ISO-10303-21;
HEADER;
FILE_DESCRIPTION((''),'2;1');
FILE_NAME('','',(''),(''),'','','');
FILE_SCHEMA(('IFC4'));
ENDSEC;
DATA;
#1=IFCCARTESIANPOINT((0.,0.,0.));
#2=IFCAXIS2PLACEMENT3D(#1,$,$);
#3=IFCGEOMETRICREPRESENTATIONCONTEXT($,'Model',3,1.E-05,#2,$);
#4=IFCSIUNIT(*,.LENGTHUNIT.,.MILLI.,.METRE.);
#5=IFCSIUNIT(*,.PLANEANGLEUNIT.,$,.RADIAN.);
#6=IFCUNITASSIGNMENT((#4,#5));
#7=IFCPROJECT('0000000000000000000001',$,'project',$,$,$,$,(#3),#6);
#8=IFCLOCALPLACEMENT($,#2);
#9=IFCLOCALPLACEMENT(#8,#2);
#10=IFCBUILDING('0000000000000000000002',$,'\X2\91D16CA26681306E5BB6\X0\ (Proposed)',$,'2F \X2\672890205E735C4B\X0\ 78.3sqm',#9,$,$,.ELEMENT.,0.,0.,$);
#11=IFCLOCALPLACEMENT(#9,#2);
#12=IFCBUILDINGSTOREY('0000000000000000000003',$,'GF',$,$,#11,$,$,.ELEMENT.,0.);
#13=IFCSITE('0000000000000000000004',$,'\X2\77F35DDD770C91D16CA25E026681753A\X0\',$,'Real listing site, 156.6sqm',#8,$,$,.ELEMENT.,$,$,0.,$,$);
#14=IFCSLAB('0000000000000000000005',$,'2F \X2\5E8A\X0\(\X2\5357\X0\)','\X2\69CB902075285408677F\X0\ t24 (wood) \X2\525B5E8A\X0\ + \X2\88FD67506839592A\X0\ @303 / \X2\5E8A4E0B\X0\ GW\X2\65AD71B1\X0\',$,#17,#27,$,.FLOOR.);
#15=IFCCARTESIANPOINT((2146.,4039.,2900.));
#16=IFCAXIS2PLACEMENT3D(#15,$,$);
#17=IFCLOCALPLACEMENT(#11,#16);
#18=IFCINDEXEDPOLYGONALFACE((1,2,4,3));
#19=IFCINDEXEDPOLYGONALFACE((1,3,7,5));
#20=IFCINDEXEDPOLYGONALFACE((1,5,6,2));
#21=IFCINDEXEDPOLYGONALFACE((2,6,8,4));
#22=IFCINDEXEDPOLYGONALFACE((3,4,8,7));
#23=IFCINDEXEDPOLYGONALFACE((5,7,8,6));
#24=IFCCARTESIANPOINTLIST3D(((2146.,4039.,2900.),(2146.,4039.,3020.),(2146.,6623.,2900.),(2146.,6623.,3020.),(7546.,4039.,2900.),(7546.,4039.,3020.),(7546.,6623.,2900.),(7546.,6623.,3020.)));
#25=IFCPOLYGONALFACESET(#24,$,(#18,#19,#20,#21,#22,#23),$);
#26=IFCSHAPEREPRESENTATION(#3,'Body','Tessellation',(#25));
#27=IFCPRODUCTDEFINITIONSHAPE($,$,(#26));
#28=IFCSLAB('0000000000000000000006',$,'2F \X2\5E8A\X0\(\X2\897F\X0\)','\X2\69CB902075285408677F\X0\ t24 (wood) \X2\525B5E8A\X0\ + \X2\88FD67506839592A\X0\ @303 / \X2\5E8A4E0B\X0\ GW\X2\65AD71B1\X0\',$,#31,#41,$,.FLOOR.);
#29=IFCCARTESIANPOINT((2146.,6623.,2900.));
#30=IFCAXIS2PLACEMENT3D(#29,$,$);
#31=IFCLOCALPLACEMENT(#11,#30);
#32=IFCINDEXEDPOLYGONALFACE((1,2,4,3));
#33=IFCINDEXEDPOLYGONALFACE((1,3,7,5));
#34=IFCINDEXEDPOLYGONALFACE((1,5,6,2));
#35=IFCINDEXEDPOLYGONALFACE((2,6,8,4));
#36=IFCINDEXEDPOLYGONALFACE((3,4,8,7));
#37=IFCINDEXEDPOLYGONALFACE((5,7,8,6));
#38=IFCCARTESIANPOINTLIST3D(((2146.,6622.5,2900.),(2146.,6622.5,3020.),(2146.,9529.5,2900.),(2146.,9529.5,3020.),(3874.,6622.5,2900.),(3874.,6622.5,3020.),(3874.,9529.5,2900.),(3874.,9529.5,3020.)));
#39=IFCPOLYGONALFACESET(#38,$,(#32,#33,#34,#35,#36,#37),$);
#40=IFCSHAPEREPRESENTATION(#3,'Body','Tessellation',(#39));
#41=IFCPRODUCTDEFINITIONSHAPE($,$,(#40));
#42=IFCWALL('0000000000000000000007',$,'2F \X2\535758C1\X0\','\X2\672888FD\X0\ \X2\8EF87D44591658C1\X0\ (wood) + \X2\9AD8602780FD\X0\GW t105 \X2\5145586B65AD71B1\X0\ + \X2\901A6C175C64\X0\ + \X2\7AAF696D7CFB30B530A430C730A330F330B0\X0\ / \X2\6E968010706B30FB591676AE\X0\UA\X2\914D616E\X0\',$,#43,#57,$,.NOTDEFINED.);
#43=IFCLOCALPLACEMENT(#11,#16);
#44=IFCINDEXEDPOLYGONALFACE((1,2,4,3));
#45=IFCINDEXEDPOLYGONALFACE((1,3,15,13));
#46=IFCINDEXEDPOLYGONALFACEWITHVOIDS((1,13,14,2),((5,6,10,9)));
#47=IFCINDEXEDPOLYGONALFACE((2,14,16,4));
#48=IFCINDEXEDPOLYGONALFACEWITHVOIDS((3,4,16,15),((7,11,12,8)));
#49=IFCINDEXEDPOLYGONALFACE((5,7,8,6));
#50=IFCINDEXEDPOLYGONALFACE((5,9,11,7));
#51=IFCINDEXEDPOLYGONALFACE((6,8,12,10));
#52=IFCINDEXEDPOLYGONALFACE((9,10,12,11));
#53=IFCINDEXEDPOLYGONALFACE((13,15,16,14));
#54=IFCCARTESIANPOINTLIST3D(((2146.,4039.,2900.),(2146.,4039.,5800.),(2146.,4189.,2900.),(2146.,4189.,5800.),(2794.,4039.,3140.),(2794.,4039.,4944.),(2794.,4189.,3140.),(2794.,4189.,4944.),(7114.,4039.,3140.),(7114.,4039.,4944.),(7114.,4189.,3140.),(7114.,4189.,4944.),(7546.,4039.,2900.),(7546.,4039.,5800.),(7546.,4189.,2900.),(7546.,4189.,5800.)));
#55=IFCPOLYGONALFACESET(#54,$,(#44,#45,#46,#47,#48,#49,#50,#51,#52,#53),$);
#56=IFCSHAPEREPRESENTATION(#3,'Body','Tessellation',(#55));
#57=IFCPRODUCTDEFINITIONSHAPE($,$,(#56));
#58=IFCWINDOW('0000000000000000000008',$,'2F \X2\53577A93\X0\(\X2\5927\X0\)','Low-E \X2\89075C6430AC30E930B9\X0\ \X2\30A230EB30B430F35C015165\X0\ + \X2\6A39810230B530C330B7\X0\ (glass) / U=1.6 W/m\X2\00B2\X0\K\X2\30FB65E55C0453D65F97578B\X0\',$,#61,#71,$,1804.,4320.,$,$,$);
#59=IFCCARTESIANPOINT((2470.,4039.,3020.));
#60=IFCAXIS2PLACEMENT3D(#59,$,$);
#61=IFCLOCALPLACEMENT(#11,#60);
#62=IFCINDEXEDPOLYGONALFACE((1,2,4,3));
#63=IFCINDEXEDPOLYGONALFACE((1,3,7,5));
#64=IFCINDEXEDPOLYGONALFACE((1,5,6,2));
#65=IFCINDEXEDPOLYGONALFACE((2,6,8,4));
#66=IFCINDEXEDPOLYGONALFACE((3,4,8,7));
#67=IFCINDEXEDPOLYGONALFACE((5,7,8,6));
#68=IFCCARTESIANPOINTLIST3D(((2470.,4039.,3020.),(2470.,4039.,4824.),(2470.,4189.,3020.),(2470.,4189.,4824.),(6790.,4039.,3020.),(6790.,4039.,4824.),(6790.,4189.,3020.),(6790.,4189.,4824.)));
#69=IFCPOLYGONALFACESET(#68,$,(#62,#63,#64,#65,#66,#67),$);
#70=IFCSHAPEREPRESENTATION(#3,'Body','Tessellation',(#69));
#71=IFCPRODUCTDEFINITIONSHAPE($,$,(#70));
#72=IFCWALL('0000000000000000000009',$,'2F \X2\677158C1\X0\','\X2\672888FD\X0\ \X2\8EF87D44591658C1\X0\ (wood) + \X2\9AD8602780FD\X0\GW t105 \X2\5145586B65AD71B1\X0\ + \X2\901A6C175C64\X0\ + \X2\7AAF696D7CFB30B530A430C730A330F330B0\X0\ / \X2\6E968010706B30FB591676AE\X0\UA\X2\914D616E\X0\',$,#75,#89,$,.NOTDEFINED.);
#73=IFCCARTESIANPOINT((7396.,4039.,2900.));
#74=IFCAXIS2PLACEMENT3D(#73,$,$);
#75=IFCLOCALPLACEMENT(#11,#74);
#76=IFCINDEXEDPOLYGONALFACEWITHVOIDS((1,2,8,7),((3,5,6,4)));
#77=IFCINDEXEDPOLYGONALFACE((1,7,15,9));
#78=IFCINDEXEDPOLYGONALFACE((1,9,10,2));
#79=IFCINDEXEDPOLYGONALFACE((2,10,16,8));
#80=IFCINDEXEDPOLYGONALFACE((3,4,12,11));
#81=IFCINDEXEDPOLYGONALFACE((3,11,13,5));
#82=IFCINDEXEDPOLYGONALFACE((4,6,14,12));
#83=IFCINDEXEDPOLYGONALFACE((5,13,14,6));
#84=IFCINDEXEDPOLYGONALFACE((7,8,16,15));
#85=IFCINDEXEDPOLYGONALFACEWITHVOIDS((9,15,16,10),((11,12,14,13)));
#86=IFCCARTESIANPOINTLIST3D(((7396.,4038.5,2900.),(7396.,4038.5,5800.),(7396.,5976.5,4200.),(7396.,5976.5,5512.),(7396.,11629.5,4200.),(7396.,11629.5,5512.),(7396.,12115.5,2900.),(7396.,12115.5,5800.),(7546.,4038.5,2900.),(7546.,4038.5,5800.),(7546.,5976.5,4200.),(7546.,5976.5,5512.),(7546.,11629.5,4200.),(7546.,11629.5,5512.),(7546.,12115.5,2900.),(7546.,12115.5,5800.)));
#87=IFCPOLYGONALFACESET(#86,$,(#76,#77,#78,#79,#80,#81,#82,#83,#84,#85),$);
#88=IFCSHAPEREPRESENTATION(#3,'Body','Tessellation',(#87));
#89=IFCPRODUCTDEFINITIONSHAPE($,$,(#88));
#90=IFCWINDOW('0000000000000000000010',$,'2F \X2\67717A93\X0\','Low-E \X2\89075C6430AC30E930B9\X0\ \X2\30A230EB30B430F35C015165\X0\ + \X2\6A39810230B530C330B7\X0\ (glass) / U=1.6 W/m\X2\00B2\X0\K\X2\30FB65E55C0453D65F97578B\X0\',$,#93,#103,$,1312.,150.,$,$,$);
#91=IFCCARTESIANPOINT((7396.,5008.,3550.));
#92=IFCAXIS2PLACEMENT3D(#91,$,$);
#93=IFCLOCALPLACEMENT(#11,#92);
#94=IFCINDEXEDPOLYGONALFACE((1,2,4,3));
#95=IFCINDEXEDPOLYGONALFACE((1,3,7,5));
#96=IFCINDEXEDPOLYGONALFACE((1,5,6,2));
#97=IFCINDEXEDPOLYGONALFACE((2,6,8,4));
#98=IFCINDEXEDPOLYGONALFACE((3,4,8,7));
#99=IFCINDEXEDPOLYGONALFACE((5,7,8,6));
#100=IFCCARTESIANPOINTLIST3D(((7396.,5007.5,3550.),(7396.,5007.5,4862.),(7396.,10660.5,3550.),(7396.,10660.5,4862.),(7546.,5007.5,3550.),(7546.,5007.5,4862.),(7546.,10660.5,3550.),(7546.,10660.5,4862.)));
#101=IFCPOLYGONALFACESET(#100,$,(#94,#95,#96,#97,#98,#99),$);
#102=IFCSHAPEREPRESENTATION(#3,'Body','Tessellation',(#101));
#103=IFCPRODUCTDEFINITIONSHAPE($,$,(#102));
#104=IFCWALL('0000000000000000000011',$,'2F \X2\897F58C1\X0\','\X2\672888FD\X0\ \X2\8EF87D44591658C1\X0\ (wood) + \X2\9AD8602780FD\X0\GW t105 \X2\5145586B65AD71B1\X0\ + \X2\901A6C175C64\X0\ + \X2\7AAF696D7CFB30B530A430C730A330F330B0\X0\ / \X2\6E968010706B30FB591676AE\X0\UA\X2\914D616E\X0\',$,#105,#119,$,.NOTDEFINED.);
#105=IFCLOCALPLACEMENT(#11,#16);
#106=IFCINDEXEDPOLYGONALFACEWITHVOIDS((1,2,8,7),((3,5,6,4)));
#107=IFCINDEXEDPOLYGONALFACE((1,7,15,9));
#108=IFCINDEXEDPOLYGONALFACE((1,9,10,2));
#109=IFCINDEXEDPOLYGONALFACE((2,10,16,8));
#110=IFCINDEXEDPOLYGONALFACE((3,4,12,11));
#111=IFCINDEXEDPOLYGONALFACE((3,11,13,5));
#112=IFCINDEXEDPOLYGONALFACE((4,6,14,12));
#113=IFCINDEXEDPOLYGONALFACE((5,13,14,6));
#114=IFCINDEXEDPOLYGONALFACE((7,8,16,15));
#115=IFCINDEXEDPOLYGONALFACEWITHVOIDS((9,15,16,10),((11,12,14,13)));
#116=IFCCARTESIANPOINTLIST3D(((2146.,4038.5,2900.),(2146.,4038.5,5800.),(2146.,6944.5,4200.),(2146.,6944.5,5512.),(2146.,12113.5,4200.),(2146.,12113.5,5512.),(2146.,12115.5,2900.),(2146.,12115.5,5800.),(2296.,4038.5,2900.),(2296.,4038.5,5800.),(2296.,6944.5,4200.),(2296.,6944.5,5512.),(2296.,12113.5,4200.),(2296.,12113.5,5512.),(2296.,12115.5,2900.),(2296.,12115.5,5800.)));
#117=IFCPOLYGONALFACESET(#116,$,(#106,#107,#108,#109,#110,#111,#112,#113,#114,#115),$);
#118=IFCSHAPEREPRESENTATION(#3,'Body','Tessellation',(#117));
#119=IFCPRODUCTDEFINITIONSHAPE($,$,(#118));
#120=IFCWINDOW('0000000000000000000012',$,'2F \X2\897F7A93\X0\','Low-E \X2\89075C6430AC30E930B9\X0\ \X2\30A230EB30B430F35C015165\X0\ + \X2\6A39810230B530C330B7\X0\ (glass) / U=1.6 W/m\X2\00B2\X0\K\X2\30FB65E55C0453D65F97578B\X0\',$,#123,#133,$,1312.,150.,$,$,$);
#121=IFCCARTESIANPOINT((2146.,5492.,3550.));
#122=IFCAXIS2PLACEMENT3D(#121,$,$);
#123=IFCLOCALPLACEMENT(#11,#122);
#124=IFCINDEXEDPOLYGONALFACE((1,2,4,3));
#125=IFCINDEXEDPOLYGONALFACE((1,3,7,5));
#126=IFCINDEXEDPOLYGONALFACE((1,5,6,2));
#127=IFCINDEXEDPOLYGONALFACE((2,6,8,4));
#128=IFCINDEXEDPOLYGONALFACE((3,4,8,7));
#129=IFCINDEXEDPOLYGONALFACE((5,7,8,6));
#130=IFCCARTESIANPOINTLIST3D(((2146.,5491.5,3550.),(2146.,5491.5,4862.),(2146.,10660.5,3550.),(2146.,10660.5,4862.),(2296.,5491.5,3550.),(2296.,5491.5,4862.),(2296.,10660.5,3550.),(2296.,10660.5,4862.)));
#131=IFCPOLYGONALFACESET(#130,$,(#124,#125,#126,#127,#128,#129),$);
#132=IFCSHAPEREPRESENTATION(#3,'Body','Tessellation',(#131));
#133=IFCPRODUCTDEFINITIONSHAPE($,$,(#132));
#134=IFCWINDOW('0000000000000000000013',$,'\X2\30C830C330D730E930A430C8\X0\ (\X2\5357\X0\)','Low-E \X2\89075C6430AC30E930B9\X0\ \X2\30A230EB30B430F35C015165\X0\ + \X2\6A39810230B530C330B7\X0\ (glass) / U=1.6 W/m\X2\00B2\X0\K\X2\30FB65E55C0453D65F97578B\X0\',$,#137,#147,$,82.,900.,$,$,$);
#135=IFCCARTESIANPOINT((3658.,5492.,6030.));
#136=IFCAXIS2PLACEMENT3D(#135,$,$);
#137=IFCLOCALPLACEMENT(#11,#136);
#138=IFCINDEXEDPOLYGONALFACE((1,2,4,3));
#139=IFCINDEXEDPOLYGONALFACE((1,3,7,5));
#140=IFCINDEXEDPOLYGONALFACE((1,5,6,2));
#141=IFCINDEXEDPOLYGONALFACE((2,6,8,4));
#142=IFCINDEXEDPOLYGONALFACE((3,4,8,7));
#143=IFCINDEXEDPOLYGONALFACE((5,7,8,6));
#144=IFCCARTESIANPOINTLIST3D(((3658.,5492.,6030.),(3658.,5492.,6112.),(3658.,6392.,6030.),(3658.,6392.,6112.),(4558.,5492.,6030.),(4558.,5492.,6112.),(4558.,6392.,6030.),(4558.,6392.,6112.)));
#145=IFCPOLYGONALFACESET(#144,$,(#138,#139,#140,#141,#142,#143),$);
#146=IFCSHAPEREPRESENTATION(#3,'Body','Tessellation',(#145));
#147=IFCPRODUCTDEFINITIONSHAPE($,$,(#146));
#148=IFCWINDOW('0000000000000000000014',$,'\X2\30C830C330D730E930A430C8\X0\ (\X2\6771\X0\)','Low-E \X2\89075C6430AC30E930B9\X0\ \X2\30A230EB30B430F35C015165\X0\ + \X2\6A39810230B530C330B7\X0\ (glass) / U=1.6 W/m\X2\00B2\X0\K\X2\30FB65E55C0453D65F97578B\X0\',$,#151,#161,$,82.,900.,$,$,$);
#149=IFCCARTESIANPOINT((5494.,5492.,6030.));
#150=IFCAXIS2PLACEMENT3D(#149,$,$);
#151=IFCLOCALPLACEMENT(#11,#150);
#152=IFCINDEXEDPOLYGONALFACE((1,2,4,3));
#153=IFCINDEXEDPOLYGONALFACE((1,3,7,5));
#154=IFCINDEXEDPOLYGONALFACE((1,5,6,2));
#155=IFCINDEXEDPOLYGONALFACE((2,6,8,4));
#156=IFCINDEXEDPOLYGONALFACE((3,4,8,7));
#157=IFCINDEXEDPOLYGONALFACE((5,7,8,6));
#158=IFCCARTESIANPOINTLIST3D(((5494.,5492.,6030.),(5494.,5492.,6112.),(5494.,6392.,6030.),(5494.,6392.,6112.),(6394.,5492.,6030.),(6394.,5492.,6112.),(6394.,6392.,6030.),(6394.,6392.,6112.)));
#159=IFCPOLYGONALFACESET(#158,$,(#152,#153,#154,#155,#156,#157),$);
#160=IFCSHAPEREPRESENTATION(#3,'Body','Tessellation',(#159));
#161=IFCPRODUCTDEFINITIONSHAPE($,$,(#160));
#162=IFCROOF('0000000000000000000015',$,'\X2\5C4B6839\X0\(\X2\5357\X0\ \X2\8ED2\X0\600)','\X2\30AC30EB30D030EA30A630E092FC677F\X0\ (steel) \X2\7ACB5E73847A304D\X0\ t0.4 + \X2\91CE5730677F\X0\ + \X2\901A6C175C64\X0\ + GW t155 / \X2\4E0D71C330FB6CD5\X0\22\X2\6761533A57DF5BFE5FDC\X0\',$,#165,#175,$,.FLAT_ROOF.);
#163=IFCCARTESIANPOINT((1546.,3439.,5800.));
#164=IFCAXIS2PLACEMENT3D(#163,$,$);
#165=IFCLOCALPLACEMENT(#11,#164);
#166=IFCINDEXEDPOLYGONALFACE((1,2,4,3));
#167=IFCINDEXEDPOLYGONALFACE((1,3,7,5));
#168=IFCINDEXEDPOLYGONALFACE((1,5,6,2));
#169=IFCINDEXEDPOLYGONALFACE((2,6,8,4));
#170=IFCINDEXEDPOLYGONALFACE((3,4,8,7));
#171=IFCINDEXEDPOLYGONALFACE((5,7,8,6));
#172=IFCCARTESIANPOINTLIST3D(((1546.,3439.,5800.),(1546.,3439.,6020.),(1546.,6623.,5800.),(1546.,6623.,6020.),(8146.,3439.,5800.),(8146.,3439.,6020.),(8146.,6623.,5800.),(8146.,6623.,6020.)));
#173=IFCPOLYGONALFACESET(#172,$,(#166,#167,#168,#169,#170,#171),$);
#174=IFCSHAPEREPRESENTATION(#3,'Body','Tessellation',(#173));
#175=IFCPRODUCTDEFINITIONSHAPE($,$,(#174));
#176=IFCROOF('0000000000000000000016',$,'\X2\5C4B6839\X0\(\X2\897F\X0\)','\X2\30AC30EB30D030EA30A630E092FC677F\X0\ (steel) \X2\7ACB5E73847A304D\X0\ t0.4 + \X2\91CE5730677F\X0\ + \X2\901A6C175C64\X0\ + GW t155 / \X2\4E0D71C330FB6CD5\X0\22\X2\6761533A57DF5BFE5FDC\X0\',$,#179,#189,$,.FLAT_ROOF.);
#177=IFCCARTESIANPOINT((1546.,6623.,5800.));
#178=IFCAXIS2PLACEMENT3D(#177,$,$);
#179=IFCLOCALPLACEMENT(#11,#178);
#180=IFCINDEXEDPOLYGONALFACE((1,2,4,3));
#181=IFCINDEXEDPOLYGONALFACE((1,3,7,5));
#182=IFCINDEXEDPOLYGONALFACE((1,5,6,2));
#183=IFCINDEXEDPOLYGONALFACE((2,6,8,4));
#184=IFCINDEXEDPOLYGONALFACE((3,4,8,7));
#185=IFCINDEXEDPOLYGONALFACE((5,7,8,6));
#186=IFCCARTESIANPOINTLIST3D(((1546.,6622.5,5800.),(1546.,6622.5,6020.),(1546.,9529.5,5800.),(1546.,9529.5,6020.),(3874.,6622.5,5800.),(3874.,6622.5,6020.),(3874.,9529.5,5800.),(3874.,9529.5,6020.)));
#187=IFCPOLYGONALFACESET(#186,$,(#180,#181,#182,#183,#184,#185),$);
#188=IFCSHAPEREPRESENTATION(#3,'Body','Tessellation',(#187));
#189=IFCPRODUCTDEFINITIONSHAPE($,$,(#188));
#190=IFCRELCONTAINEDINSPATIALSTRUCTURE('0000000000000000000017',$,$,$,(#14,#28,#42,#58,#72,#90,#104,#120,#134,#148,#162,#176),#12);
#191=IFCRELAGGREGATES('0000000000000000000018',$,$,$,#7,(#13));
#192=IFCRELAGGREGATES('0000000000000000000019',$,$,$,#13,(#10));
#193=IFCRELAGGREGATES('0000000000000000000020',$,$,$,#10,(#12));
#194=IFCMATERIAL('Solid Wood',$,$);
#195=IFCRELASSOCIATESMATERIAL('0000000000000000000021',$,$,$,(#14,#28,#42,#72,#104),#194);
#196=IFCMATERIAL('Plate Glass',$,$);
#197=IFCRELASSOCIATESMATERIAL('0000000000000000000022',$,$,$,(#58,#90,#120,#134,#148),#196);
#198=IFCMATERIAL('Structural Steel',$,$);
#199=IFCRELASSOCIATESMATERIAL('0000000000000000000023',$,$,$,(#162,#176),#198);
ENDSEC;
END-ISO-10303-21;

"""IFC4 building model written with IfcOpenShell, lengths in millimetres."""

from ifc_helpers import new_model, si_unit, frame, frame_2d, origin, place, context, project, spatial, rectangle, extrude, material, element, fill, save


model = new_model("IFC4")

# Units and contexts
model_context = context("Model", 3, precision=1e-05, world=origin())
ifc_project = project(units=[si_unit("LENGTHUNIT", "METRE", prefix="MILLI"), si_unit("PLANEANGLEUNIT", "RADIAN")], contexts=[model_context])

# Site, building, storey
site_placement = place(None, origin())
site = spatial("IfcSite", under=ifc_project, at=site_placement, Name="石川県金沢市暁町", ObjectType="Real listing site, 156.6sqm", CompositionType="ELEMENT", RefElevation=0.0)
building_placement = place(site_placement, origin())
building = spatial("IfcBuilding", under=site, at=building_placement, Name="金沢暁の家 (Proposed)", ObjectType="2F 木造平屋 78.3sqm", CompositionType="ELEMENT", ElevationOfRefHeight=0.0, ElevationOfTerrain=0.0)
storey_placement = place(building_placement, origin())
storey = spatial("IfcBuildingStorey", under=building, at=storey_placement, Name="GF", CompositionType="ELEMENT", Elevation=0.0)

# Slabs
ifc_material_1 = material(Name="Solid Wood")
slab_1_placement = place(storey_placement, frame((2146.0, 4039.0, 2900.0)))
element("IfcSlab", 1, at=slab_1_placement, inside=storey, material=ifc_material_1, Name="2F 床(南)", Description="構造用合板 t24 (wood) 剛床 + 製材根太 @303 / 床下 GW断熱", PredefinedType="FLOOR", context=model_context, shape_type="SweptSolid", body=[
    extrude(rectangle(XDim=5400.0, YDim=2584.0, at=frame_2d((2700.0, 1292.0))), frame((2146.0, 4039.0, 2900.0)), (0.0, 0.0, 1.0), 120.0),
])
slab_2_placement = place(storey_placement, frame((2146.0, 6623.0, 2900.0)))
element("IfcSlab", 2, at=slab_2_placement, inside=storey, material=ifc_material_1, Name="2F 床(西)", Description="構造用合板 t24 (wood) 剛床 + 製材根太 @303 / 床下 GW断熱", PredefinedType="FLOOR", context=model_context, shape_type="SweptSolid", body=[
    extrude(rectangle(XDim=1728.0, YDim=2907.0, at=frame_2d((864.0, 1453.0))), frame((2146.0, 6623.0, 2900.0)), (0.0, 0.0, 1.0), 120.0),
])

# Walls, openings, windows
wall_1_placement = place(storey_placement, frame((2146.0, 4039.0, 2900.0)))
wall_1 = element("IfcWall", 3, at=wall_1_placement, inside=storey, material=ifc_material_1, Name="2F 南壁", Description="木製 軸組外壁 (wood) + 高性能GW t105 充填断熱 + 通気層 + 窯業系サイディング / 準耐火・外皮UA配慮", PredefinedType="NOTDEFINED", context=model_context, shape_type="SweptSolid", body=[
    extrude(rectangle(XDim=5400.0, YDim=150.0, at=frame_2d((2700.0, 75.0))), frame((2146.0, 4039.0, 2900.0)), (0.0, 0.0, 1.0), 2900.0),
])
opening_1_placement = place(storey_placement, frame((2470.0, 4039.0, 3020.0)))
opening_1 = element("IfcOpeningElement", 4, at=opening_1_placement, cuts=wall_1, PredefinedType="NOTDEFINED", context=model_context, shape_type="SweptSolid", body=[
    extrude(rectangle(XDim=4320.0, YDim=150.0, at=frame_2d((2160.0, 75.0))), frame((2470.0, 4039.0, 3020.0)), (0.0, 0.0, 1.0), 1804.0),
])
ifc_material_2 = material(Name="Plate Glass")
window_1_placement = place(storey_placement, frame((2470.0, 4039.0, 3020.0)))
window_1 = element("IfcWindow", 5, at=window_1_placement, inside=storey, material=ifc_material_2, Name="2F 南窓(大)", Description="Low-E 複層ガラス アルゴン封入 + 樹脂サッシ (glass) / U=1.6 W/m²K・日射取得型", OverallHeight=1804.0, OverallWidth=4320.0, context=model_context, shape_type="SweptSolid", body=[
    extrude(rectangle(XDim=4320.0, YDim=150.0, at=frame_2d((2160.0, 75.0))), frame((2470.0, 4039.0, 3020.0)), (0.0, 0.0, 1.0), 1804.0),
])
fill(opening_1, window_1)
wall_2_placement = place(storey_placement, frame((7396.0, 4039.0, 2900.0)))
wall_2 = element("IfcWall", 6, at=wall_2_placement, inside=storey, material=ifc_material_1, Name="2F 東壁", Description="木製 軸組外壁 (wood) + 高性能GW t105 充填断熱 + 通気層 + 窯業系サイディング / 準耐火・外皮UA配慮", PredefinedType="NOTDEFINED", context=model_context, shape_type="SweptSolid", body=[
    extrude(rectangle(XDim=150.0, YDim=8077.0, at=frame_2d((75.0, 4038.0))), frame((7396.0, 4039.0, 2900.0)), (0.0, 0.0, 1.0), 2900.0),
])
opening_2_placement = place(storey_placement, frame((7396.0, 5008.0, 3550.0)))
opening_2 = element("IfcOpeningElement", 7, at=opening_2_placement, cuts=wall_2, PredefinedType="NOTDEFINED", context=model_context, shape_type="SweptSolid", body=[
    extrude(rectangle(XDim=150.0, YDim=5653.0, at=frame_2d((75.0, 2826.0))), frame((7396.0, 5008.0, 3550.0)), (0.0, 0.0, 1.0), 1312.0),
])
window_2_placement = place(storey_placement, frame((7396.0, 5008.0, 3550.0)))
window_2 = element("IfcWindow", 8, at=window_2_placement, inside=storey, material=ifc_material_2, Name="2F 東窓", Description="Low-E 複層ガラス アルゴン封入 + 樹脂サッシ (glass) / U=1.6 W/m²K・日射取得型", OverallHeight=1312.0, OverallWidth=150.0, context=model_context, shape_type="SweptSolid", body=[
    extrude(rectangle(XDim=150.0, YDim=5653.0, at=frame_2d((75.0, 2826.0))), frame((7396.0, 5008.0, 3550.0)), (0.0, 0.0, 1.0), 1312.0),
])
fill(opening_2, window_2)
wall_3_placement = place(storey_placement, frame((2146.0, 4039.0, 2900.0)))
wall_3 = element("IfcWall", 9, at=wall_3_placement, inside=storey, material=ifc_material_1, Name="2F 西壁", Description="木製 軸組外壁 (wood) + 高性能GW t105 充填断熱 + 通気層 + 窯業系サイディング / 準耐火・外皮UA配慮", PredefinedType="NOTDEFINED", context=model_context, shape_type="SweptSolid", body=[
    extrude(rectangle(XDim=150.0, YDim=8077.0, at=frame_2d((75.0, 4038.0))), frame((2146.0, 4039.0, 2900.0)), (0.0, 0.0, 1.0), 2900.0),
])
opening_3_placement = place(storey_placement, frame((2146.0, 5492.0, 3550.0)))
opening_3 = element("IfcOpeningElement", 10, at=opening_3_placement, cuts=wall_3, PredefinedType="NOTDEFINED", context=model_context, shape_type="SweptSolid", body=[
    extrude(rectangle(XDim=150.0, YDim=5169.0, at=frame_2d((75.0, 2584.0))), frame((2146.0, 5492.0, 3550.0)), (0.0, 0.0, 1.0), 1312.0),
])
window_3_placement = place(storey_placement, frame((2146.0, 5492.0, 3550.0)))
window_3 = element("IfcWindow", 11, at=window_3_placement, inside=storey, material=ifc_material_2, Name="2F 西窓", Description="Low-E 複層ガラス アルゴン封入 + 樹脂サッシ (glass) / U=1.6 W/m²K・日射取得型", OverallHeight=1312.0, OverallWidth=150.0, context=model_context, shape_type="SweptSolid", body=[
    extrude(rectangle(XDim=150.0, YDim=5169.0, at=frame_2d((75.0, 2584.0))), frame((2146.0, 5492.0, 3550.0)), (0.0, 0.0, 1.0), 1312.0),
])
fill(opening_3, window_3)

# Windows
window_4_placement = place(storey_placement, frame((3658.0, 5492.0, 6030.0)))
element("IfcWindow", 12, at=window_4_placement, inside=storey, material=ifc_material_2, Name="トップライト (南)", Description="Low-E 複層ガラス アルゴン封入 + 樹脂サッシ (glass) / U=1.6 W/m²K・日射取得型", OverallHeight=82.0, OverallWidth=900.0, context=model_context, shape_type="SweptSolid", body=[
    extrude(rectangle(XDim=900.0, YDim=900.0, at=frame_2d((450.0, 450.0))), frame((3658.0, 5492.0, 6030.0)), (0.0, 0.0, 1.0), 82.0),
])
window_5_placement = place(storey_placement, frame((5494.0, 5492.0, 6030.0)))
element("IfcWindow", 13, at=window_5_placement, inside=storey, material=ifc_material_2, Name="トップライト (東)", Description="Low-E 複層ガラス アルゴン封入 + 樹脂サッシ (glass) / U=1.6 W/m²K・日射取得型", OverallHeight=82.0, OverallWidth=900.0, context=model_context, shape_type="SweptSolid", body=[
    extrude(rectangle(XDim=900.0, YDim=900.0, at=frame_2d((450.0, 450.0))), frame((5494.0, 5492.0, 6030.0)), (0.0, 0.0, 1.0), 82.0),
])

# Roofs
ifc_material_3 = material(Name="Structural Steel")
roof_1_placement = place(storey_placement, frame((1546.0, 3439.0, 5800.0)))
element("IfcRoof", 14, at=roof_1_placement, inside=storey, material=ifc_material_3, Name="屋根(南 軒600)", Description="ガルバリウム鋼板 (steel) 立平葺き t0.4 + 野地板 + 通気層 + GW t155 / 不燃・法22条区域対応", PredefinedType="FLAT_ROOF", context=model_context, shape_type="SweptSolid", body=[
    extrude(rectangle(XDim=6600.0, YDim=3184.0, at=frame_2d((3300.0, 1592.0))), frame((1546.0, 3439.0, 5800.0)), (0.0, 0.0, 1.0), 220.0),
])
roof_2_placement = place(storey_placement, frame((1546.0, 6623.0, 5800.0)))
element("IfcRoof", 15, at=roof_2_placement, inside=storey, material=ifc_material_3, Name="屋根(西)", Description="ガルバリウム鋼板 (steel) 立平葺き t0.4 + 野地板 + 通気層 + GW t155 / 不燃・法22条区域対応", PredefinedType="FLAT_ROOF", context=model_context, shape_type="SweptSolid", body=[
    extrude(rectangle(XDim=2328.0, YDim=2907.0, at=frame_2d((1164.0, 1453.0))), frame((1546.0, 6623.0, 5800.0)), (0.0, 0.0, 1.0), 220.0),
])

save(model, "model.ifc")
